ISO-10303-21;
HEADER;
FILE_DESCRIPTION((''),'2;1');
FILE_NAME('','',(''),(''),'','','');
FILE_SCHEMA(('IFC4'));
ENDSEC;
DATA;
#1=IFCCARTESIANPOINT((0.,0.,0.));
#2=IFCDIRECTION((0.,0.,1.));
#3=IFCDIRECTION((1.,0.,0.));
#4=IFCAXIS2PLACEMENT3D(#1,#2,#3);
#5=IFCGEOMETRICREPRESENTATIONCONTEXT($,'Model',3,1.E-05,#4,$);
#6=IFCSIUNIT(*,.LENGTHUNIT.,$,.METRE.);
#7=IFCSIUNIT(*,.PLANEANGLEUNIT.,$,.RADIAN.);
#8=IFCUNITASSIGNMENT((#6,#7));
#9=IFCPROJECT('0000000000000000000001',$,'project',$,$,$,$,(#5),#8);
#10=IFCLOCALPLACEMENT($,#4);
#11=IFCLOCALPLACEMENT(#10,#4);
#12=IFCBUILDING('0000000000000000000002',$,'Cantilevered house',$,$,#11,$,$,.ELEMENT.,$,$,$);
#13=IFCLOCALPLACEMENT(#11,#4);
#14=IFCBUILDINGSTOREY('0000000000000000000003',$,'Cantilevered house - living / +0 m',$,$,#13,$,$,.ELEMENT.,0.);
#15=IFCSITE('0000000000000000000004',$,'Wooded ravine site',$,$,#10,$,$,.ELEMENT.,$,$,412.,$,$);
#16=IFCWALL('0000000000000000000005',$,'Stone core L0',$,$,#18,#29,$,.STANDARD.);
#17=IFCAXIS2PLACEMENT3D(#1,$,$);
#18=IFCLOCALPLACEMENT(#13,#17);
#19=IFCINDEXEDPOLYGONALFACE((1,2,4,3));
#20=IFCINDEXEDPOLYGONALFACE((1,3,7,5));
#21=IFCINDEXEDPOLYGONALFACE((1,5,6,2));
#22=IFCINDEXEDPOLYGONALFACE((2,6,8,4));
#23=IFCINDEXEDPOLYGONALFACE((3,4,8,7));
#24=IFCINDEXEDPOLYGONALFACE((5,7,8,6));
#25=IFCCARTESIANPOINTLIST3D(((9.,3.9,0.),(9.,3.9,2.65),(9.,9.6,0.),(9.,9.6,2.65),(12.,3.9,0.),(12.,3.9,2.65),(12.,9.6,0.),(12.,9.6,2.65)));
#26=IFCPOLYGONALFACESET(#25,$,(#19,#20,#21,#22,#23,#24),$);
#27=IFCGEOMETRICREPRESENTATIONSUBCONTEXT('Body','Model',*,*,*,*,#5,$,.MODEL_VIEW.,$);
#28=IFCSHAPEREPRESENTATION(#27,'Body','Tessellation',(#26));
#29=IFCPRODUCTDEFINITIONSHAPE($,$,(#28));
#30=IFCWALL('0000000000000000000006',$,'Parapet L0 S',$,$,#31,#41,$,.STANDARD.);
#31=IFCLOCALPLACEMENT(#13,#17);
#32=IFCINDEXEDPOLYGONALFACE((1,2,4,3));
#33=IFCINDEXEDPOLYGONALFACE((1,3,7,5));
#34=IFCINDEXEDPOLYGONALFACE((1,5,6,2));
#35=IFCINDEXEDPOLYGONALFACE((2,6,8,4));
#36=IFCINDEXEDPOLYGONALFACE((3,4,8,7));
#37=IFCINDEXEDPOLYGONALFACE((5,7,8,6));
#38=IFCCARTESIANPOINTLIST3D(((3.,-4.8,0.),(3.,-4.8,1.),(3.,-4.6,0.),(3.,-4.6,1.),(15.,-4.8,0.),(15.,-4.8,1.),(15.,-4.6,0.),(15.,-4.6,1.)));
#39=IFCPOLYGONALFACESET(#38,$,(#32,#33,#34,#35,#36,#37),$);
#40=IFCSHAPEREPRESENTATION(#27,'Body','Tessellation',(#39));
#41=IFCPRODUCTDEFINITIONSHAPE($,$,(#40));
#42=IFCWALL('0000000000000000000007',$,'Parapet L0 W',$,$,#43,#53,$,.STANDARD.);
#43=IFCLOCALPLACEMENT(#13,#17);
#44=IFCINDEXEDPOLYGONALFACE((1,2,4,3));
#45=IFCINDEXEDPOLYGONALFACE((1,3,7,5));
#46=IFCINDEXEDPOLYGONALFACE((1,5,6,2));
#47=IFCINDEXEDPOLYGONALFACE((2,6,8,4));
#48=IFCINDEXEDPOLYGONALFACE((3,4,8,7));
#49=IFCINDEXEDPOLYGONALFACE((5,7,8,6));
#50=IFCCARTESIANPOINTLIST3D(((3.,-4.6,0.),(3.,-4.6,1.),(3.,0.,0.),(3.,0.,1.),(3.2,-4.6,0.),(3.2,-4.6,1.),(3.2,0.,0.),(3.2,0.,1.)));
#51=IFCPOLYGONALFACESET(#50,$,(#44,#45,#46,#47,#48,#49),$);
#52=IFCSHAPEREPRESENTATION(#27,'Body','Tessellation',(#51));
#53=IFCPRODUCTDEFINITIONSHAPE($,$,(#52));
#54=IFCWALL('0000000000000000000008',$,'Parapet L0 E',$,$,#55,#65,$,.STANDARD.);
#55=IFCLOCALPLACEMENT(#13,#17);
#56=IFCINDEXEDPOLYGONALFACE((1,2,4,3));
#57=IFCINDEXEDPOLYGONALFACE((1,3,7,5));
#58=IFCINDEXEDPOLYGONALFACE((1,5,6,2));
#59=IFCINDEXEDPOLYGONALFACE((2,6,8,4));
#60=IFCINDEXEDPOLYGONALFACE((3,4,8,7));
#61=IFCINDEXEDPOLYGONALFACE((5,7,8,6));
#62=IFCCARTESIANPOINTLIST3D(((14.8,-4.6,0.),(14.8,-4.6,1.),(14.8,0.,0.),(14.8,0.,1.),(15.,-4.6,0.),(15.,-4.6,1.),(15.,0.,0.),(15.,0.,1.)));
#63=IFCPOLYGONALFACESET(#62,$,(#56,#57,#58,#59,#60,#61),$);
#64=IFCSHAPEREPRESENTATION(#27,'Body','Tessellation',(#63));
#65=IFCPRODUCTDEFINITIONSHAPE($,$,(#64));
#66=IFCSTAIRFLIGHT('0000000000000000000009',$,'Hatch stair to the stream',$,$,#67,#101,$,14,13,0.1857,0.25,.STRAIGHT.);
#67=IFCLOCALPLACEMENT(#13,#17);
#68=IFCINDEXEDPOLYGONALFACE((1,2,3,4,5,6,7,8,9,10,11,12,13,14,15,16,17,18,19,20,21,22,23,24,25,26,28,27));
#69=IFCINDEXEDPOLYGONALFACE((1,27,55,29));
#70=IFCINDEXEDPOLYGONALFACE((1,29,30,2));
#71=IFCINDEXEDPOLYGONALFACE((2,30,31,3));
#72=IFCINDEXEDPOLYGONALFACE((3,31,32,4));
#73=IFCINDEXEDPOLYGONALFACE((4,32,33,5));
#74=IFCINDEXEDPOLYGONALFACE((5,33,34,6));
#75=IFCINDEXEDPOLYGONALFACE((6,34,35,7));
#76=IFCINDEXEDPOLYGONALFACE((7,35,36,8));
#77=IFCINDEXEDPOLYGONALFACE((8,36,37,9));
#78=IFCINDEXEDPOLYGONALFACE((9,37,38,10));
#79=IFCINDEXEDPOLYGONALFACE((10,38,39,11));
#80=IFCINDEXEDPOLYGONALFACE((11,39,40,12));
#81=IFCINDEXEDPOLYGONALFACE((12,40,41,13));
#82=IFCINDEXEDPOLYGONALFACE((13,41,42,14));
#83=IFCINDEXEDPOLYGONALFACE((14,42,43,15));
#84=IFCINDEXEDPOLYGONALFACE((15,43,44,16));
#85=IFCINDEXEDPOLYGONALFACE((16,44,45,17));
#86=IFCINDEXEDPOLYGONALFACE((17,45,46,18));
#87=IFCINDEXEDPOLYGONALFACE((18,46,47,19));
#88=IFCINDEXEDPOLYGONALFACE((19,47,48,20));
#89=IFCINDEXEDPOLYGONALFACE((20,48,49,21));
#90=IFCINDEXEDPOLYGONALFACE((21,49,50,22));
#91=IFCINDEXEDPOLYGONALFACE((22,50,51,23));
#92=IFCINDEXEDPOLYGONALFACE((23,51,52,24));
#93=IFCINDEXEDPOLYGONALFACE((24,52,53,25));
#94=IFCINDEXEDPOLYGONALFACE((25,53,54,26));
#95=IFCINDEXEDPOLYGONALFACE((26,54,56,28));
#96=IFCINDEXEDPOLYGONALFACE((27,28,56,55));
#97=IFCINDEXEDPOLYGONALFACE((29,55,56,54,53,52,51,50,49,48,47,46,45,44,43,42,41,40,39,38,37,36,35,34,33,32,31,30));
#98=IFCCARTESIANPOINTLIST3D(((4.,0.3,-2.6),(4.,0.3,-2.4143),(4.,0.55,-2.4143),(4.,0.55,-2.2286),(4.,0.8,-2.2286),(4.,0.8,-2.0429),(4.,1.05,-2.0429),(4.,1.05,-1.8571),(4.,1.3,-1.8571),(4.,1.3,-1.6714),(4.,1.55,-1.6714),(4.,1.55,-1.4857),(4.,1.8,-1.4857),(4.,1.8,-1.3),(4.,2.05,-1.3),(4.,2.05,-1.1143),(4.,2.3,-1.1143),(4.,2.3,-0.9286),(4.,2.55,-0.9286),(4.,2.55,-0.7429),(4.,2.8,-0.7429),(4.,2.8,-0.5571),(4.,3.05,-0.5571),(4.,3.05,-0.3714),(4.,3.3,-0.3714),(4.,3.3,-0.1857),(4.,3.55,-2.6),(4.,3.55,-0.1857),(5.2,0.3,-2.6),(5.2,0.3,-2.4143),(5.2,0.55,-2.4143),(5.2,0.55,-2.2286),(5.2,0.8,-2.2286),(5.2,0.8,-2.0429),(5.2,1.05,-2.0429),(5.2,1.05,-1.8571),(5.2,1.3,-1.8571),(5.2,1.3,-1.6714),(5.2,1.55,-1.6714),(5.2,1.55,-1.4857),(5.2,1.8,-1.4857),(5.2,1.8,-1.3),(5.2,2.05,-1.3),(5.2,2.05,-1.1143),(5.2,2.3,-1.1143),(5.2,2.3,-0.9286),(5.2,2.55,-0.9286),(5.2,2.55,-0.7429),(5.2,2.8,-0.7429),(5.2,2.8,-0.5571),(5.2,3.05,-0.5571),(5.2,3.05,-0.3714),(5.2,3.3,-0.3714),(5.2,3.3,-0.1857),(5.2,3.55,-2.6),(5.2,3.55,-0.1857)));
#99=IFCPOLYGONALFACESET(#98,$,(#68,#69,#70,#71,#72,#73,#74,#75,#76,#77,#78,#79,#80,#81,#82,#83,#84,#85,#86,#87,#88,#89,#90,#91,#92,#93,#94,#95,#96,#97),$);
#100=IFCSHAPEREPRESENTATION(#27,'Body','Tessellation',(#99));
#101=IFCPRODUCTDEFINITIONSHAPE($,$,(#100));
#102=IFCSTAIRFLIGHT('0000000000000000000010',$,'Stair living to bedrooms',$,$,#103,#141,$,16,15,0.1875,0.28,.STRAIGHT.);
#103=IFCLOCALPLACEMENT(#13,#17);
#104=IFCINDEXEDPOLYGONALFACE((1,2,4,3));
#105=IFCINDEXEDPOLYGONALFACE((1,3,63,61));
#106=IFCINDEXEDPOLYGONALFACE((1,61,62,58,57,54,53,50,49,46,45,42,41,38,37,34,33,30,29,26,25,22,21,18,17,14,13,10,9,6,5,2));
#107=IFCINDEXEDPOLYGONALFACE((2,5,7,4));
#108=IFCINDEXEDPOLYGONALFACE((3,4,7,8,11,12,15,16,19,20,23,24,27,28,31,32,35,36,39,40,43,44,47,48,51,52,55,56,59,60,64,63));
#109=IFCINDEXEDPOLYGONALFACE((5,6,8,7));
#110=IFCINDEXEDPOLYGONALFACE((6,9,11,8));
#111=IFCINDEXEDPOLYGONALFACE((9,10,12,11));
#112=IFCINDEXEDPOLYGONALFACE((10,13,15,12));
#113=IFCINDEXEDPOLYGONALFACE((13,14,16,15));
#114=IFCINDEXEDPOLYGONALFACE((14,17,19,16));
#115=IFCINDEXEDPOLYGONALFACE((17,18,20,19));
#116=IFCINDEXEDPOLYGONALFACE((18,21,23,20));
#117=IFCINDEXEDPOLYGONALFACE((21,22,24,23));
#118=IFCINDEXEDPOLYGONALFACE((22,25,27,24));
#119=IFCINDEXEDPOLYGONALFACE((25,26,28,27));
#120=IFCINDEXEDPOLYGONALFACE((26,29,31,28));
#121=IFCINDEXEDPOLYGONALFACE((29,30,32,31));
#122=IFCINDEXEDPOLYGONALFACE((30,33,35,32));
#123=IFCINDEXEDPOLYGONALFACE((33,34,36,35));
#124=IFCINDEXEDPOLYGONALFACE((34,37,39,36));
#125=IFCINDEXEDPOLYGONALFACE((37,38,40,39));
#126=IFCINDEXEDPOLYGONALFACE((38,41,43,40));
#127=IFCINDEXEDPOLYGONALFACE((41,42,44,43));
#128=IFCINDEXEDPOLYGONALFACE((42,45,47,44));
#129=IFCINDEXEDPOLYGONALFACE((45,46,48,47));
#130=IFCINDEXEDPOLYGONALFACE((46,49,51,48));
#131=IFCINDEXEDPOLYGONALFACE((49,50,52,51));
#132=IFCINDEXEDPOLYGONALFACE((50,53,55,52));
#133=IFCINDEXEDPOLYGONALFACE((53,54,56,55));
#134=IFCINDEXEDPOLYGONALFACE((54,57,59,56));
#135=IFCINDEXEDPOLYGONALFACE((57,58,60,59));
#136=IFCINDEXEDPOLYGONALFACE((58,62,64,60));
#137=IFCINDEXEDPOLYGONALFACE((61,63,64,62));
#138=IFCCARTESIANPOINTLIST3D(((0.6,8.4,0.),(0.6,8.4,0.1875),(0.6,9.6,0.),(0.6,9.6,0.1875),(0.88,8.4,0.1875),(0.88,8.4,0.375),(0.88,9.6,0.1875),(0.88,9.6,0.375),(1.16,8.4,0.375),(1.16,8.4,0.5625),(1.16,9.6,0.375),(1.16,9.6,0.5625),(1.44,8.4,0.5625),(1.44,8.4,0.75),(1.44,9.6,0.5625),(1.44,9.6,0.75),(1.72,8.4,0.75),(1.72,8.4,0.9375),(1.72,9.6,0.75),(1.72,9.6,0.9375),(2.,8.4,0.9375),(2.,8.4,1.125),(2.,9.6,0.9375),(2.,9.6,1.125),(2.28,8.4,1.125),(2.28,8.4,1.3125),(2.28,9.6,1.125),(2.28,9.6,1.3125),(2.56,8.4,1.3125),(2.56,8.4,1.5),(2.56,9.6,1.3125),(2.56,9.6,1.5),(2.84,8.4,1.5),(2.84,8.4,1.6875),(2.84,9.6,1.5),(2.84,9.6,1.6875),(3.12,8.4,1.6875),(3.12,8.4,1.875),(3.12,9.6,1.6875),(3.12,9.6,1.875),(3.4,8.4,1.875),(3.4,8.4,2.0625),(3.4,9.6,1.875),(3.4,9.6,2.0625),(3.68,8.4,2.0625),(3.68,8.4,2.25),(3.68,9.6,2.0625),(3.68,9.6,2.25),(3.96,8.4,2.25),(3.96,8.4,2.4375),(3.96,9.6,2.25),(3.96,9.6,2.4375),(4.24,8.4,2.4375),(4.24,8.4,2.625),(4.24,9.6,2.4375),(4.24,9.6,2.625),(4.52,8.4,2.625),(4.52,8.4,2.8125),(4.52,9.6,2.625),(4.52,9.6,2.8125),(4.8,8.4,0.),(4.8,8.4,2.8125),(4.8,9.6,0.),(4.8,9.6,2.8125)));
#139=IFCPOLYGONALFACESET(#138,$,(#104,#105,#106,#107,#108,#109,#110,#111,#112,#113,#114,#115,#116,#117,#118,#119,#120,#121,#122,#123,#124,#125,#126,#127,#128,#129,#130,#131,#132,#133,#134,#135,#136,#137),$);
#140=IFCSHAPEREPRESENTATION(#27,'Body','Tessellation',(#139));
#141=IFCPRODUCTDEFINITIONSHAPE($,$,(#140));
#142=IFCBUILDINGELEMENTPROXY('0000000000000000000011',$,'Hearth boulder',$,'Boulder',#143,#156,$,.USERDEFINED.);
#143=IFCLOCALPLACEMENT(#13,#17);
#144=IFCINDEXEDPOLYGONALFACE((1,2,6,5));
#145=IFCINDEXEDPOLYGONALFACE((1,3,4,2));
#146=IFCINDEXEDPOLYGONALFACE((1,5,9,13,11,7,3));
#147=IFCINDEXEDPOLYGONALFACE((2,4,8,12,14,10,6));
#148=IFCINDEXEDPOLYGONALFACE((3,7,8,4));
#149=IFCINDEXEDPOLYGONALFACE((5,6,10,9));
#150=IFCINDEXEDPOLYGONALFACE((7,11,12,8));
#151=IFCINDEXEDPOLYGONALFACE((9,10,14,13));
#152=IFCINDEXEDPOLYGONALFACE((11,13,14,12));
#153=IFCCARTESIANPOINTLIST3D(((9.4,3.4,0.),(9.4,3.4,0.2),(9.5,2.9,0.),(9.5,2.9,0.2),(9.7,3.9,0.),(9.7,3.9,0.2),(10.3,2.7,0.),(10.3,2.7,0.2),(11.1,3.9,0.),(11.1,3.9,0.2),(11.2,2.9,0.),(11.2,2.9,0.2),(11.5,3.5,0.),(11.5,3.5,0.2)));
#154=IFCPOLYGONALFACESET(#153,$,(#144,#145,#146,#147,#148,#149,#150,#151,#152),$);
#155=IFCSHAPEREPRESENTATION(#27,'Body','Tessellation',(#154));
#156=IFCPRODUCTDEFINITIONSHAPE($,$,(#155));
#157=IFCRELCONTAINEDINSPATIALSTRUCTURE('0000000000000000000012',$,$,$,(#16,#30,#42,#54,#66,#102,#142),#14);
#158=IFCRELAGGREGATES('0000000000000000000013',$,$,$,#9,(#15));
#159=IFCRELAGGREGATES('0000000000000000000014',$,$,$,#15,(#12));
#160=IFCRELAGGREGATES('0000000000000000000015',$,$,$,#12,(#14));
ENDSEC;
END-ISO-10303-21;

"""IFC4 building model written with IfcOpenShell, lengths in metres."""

from ifc_helpers import new_model, si_unit, frame, frame_2d, origin_with_axes, place, context, subcontext, project, spatial, polyline, rectangle, outline, extrude, element, save


model = new_model("IFC4")

# Units and contexts
model_context = context("Model", 3, precision=1e-05, world=origin_with_axes())
body_context = subcontext(model_context, "Body", "Model", "MODEL_VIEW")
ifc_project = project(units=[si_unit("LENGTHUNIT", "METRE"), si_unit("PLANEANGLEUNIT", "RADIAN")], contexts=[model_context])

# Site, building, storey
site_placement = place(None, origin_with_axes())
site = spatial("IfcSite", under=ifc_project, at=site_placement, Name="Wooded ravine site", CompositionType="ELEMENT", RefElevation=412.0)
building_placement = place(site_placement, origin_with_axes())
building = spatial("IfcBuilding", under=site, at=building_placement, Name="Cantilevered house", CompositionType="ELEMENT")
storey_placement = place(building_placement, origin_with_axes())
storey = spatial("IfcBuildingStorey", under=building, at=storey_placement, Name="Cantilevered house - living / +0 m", CompositionType="ELEMENT", Elevation=0.0)

# Walls
wall_1_placement = place(storey_placement, origin_with_axes())
element("IfcWall", 1, at=wall_1_placement, inside=storey, Name="Stone core L0", PredefinedType="STANDARD", context=body_context, shape_type="SweptSolid", body=[
    extrude(rectangle(XDim=3.0, YDim=5.7, at=frame_2d((10.5, 6.75))), origin_with_axes(), (0.0, 0.0, 1.0), 2.65),
])
wall_2_placement = place(storey_placement, origin_with_axes())
element("IfcWall", 2, at=wall_2_placement, inside=storey, Name="Parapet L0 S", PredefinedType="STANDARD", context=body_context, shape_type="SweptSolid", body=[
    extrude(rectangle(XDim=12.0, YDim=0.2, at=frame_2d((9.0, -4.7))), origin_with_axes(), (0.0, 0.0, 1.0), 1.0),
])
wall_3_placement = place(storey_placement, origin_with_axes())
element("IfcWall", 3, at=wall_3_placement, inside=storey, Name="Parapet L0 W", PredefinedType="STANDARD", context=body_context, shape_type="SweptSolid", body=[
    extrude(rectangle(XDim=0.2, YDim=4.6, at=frame_2d((3.1, -2.3))), origin_with_axes(), (0.0, 0.0, 1.0), 1.0),
])
wall_4_placement = place(storey_placement, origin_with_axes())
element("IfcWall", 4, at=wall_4_placement, inside=storey, Name="Parapet L0 E", PredefinedType="STANDARD", context=body_context, shape_type="SweptSolid", body=[
    extrude(rectangle(XDim=0.2, YDim=4.6, at=frame_2d((14.9, -2.3))), origin_with_axes(), (0.0, 0.0, 1.0), 1.0),
])

# Stair flights
stair_flight_1_placement = place(storey_placement, origin_with_axes())
element("IfcStairFlight", 5, at=stair_flight_1_placement, inside=storey, Name="Hatch stair to the stream", NumberOfRisers=14, NumberOfTreads=13, PredefinedType="STRAIGHT", RiserHeight=0.1857, TreadLength=0.25, context=body_context, shape_type="SweptSolid", body=[
    extrude(outline(polyline([(0.0, 0.0), (0.0, 0.1857), (0.25, 0.1857), (0.25, 0.3714), (0.5, 0.3714), (0.5, 0.5571), (0.75, 0.5571), (0.75, 0.7429), (1.0, 0.7429), (1.0, 0.9286), (1.25, 0.9286), (1.25, 1.1143), (1.5, 1.1143), (1.5, 1.3), (1.75, 1.3), (1.75, 1.4857), (2.0, 1.4857), (2.0, 1.6714), (2.25, 1.6714), (2.25, 1.8571), (2.5, 1.8571), (2.5, 2.0429), (2.75, 2.0429), (2.75, 2.2286), (3.0, 2.2286), (3.0, 2.4143), (3.25, 2.4143), (3.25, 2.6), (3.25, 0.0), (0.0, 0.0)])), frame((4.0, 0.3, -2.6), z_axis=(1.0, 0.0, 0.0), x_axis=(0.0, 1.0, 0.0)), (0.0, 0.0, 1.0), 1.2),
])
stair_flight_2_placement = place(storey_placement, origin_with_axes())
element("IfcStairFlight", 6, at=stair_flight_2_placement, inside=storey, Name="Stair living to bedrooms", NumberOfRisers=16, NumberOfTreads=15, PredefinedType="STRAIGHT", RiserHeight=0.1875, TreadLength=0.28, context=body_context, shape_type="SweptSolid", body=[
    extrude(outline(polyline([(0.0, 0.0), (0.0, 0.1875), (0.28, 0.1875), (0.28, 0.375), (0.56, 0.375), (0.56, 0.5625), (0.84, 0.5625), (0.84, 0.75), (1.12, 0.75), (1.12, 0.9375), (1.4, 0.9375), (1.4, 1.125), (1.68, 1.125), (1.68, 1.3125), (1.96, 1.3125), (1.96, 1.5), (2.24, 1.5), (2.24, 1.6875), (2.52, 1.6875), (2.52, 1.875), (2.8, 1.875), (2.8, 2.0625), (3.08, 2.0625), (3.08, 2.25), (3.36, 2.25), (3.36, 2.4375), (3.64, 2.4375), (3.64, 2.625), (3.92, 2.625), (3.92, 2.8125), (4.2, 2.8125), (4.2, 3.0), (4.2, 0.0), (0.0, 0.0)])), frame((0.6, 9.6, 0.0), z_axis=(0.0, -1.0, 0.0), x_axis=(1.0, 0.0, 0.0)), (0.0, 0.0, 1.0), 1.2),
])

# Building element proxy
proxy_placement = place(storey_placement, origin_with_axes())
element("IfcBuildingElementProxy", 7, at=proxy_placement, inside=storey, Name="Hearth boulder", ObjectType="Boulder", PredefinedType="USERDEFINED", context=body_context, shape_type="SweptSolid", body=[
    extrude(outline(polyline([(9.5, 2.9), (10.3, 2.7), (11.2, 2.9), (11.5, 3.5), (11.1, 3.9), (9.7, 3.9), (9.4, 3.4), (9.5, 2.9)])), origin_with_axes(), (0.0, 0.0, 1.0), 0.2),
])

save(model, "model.ifc")
